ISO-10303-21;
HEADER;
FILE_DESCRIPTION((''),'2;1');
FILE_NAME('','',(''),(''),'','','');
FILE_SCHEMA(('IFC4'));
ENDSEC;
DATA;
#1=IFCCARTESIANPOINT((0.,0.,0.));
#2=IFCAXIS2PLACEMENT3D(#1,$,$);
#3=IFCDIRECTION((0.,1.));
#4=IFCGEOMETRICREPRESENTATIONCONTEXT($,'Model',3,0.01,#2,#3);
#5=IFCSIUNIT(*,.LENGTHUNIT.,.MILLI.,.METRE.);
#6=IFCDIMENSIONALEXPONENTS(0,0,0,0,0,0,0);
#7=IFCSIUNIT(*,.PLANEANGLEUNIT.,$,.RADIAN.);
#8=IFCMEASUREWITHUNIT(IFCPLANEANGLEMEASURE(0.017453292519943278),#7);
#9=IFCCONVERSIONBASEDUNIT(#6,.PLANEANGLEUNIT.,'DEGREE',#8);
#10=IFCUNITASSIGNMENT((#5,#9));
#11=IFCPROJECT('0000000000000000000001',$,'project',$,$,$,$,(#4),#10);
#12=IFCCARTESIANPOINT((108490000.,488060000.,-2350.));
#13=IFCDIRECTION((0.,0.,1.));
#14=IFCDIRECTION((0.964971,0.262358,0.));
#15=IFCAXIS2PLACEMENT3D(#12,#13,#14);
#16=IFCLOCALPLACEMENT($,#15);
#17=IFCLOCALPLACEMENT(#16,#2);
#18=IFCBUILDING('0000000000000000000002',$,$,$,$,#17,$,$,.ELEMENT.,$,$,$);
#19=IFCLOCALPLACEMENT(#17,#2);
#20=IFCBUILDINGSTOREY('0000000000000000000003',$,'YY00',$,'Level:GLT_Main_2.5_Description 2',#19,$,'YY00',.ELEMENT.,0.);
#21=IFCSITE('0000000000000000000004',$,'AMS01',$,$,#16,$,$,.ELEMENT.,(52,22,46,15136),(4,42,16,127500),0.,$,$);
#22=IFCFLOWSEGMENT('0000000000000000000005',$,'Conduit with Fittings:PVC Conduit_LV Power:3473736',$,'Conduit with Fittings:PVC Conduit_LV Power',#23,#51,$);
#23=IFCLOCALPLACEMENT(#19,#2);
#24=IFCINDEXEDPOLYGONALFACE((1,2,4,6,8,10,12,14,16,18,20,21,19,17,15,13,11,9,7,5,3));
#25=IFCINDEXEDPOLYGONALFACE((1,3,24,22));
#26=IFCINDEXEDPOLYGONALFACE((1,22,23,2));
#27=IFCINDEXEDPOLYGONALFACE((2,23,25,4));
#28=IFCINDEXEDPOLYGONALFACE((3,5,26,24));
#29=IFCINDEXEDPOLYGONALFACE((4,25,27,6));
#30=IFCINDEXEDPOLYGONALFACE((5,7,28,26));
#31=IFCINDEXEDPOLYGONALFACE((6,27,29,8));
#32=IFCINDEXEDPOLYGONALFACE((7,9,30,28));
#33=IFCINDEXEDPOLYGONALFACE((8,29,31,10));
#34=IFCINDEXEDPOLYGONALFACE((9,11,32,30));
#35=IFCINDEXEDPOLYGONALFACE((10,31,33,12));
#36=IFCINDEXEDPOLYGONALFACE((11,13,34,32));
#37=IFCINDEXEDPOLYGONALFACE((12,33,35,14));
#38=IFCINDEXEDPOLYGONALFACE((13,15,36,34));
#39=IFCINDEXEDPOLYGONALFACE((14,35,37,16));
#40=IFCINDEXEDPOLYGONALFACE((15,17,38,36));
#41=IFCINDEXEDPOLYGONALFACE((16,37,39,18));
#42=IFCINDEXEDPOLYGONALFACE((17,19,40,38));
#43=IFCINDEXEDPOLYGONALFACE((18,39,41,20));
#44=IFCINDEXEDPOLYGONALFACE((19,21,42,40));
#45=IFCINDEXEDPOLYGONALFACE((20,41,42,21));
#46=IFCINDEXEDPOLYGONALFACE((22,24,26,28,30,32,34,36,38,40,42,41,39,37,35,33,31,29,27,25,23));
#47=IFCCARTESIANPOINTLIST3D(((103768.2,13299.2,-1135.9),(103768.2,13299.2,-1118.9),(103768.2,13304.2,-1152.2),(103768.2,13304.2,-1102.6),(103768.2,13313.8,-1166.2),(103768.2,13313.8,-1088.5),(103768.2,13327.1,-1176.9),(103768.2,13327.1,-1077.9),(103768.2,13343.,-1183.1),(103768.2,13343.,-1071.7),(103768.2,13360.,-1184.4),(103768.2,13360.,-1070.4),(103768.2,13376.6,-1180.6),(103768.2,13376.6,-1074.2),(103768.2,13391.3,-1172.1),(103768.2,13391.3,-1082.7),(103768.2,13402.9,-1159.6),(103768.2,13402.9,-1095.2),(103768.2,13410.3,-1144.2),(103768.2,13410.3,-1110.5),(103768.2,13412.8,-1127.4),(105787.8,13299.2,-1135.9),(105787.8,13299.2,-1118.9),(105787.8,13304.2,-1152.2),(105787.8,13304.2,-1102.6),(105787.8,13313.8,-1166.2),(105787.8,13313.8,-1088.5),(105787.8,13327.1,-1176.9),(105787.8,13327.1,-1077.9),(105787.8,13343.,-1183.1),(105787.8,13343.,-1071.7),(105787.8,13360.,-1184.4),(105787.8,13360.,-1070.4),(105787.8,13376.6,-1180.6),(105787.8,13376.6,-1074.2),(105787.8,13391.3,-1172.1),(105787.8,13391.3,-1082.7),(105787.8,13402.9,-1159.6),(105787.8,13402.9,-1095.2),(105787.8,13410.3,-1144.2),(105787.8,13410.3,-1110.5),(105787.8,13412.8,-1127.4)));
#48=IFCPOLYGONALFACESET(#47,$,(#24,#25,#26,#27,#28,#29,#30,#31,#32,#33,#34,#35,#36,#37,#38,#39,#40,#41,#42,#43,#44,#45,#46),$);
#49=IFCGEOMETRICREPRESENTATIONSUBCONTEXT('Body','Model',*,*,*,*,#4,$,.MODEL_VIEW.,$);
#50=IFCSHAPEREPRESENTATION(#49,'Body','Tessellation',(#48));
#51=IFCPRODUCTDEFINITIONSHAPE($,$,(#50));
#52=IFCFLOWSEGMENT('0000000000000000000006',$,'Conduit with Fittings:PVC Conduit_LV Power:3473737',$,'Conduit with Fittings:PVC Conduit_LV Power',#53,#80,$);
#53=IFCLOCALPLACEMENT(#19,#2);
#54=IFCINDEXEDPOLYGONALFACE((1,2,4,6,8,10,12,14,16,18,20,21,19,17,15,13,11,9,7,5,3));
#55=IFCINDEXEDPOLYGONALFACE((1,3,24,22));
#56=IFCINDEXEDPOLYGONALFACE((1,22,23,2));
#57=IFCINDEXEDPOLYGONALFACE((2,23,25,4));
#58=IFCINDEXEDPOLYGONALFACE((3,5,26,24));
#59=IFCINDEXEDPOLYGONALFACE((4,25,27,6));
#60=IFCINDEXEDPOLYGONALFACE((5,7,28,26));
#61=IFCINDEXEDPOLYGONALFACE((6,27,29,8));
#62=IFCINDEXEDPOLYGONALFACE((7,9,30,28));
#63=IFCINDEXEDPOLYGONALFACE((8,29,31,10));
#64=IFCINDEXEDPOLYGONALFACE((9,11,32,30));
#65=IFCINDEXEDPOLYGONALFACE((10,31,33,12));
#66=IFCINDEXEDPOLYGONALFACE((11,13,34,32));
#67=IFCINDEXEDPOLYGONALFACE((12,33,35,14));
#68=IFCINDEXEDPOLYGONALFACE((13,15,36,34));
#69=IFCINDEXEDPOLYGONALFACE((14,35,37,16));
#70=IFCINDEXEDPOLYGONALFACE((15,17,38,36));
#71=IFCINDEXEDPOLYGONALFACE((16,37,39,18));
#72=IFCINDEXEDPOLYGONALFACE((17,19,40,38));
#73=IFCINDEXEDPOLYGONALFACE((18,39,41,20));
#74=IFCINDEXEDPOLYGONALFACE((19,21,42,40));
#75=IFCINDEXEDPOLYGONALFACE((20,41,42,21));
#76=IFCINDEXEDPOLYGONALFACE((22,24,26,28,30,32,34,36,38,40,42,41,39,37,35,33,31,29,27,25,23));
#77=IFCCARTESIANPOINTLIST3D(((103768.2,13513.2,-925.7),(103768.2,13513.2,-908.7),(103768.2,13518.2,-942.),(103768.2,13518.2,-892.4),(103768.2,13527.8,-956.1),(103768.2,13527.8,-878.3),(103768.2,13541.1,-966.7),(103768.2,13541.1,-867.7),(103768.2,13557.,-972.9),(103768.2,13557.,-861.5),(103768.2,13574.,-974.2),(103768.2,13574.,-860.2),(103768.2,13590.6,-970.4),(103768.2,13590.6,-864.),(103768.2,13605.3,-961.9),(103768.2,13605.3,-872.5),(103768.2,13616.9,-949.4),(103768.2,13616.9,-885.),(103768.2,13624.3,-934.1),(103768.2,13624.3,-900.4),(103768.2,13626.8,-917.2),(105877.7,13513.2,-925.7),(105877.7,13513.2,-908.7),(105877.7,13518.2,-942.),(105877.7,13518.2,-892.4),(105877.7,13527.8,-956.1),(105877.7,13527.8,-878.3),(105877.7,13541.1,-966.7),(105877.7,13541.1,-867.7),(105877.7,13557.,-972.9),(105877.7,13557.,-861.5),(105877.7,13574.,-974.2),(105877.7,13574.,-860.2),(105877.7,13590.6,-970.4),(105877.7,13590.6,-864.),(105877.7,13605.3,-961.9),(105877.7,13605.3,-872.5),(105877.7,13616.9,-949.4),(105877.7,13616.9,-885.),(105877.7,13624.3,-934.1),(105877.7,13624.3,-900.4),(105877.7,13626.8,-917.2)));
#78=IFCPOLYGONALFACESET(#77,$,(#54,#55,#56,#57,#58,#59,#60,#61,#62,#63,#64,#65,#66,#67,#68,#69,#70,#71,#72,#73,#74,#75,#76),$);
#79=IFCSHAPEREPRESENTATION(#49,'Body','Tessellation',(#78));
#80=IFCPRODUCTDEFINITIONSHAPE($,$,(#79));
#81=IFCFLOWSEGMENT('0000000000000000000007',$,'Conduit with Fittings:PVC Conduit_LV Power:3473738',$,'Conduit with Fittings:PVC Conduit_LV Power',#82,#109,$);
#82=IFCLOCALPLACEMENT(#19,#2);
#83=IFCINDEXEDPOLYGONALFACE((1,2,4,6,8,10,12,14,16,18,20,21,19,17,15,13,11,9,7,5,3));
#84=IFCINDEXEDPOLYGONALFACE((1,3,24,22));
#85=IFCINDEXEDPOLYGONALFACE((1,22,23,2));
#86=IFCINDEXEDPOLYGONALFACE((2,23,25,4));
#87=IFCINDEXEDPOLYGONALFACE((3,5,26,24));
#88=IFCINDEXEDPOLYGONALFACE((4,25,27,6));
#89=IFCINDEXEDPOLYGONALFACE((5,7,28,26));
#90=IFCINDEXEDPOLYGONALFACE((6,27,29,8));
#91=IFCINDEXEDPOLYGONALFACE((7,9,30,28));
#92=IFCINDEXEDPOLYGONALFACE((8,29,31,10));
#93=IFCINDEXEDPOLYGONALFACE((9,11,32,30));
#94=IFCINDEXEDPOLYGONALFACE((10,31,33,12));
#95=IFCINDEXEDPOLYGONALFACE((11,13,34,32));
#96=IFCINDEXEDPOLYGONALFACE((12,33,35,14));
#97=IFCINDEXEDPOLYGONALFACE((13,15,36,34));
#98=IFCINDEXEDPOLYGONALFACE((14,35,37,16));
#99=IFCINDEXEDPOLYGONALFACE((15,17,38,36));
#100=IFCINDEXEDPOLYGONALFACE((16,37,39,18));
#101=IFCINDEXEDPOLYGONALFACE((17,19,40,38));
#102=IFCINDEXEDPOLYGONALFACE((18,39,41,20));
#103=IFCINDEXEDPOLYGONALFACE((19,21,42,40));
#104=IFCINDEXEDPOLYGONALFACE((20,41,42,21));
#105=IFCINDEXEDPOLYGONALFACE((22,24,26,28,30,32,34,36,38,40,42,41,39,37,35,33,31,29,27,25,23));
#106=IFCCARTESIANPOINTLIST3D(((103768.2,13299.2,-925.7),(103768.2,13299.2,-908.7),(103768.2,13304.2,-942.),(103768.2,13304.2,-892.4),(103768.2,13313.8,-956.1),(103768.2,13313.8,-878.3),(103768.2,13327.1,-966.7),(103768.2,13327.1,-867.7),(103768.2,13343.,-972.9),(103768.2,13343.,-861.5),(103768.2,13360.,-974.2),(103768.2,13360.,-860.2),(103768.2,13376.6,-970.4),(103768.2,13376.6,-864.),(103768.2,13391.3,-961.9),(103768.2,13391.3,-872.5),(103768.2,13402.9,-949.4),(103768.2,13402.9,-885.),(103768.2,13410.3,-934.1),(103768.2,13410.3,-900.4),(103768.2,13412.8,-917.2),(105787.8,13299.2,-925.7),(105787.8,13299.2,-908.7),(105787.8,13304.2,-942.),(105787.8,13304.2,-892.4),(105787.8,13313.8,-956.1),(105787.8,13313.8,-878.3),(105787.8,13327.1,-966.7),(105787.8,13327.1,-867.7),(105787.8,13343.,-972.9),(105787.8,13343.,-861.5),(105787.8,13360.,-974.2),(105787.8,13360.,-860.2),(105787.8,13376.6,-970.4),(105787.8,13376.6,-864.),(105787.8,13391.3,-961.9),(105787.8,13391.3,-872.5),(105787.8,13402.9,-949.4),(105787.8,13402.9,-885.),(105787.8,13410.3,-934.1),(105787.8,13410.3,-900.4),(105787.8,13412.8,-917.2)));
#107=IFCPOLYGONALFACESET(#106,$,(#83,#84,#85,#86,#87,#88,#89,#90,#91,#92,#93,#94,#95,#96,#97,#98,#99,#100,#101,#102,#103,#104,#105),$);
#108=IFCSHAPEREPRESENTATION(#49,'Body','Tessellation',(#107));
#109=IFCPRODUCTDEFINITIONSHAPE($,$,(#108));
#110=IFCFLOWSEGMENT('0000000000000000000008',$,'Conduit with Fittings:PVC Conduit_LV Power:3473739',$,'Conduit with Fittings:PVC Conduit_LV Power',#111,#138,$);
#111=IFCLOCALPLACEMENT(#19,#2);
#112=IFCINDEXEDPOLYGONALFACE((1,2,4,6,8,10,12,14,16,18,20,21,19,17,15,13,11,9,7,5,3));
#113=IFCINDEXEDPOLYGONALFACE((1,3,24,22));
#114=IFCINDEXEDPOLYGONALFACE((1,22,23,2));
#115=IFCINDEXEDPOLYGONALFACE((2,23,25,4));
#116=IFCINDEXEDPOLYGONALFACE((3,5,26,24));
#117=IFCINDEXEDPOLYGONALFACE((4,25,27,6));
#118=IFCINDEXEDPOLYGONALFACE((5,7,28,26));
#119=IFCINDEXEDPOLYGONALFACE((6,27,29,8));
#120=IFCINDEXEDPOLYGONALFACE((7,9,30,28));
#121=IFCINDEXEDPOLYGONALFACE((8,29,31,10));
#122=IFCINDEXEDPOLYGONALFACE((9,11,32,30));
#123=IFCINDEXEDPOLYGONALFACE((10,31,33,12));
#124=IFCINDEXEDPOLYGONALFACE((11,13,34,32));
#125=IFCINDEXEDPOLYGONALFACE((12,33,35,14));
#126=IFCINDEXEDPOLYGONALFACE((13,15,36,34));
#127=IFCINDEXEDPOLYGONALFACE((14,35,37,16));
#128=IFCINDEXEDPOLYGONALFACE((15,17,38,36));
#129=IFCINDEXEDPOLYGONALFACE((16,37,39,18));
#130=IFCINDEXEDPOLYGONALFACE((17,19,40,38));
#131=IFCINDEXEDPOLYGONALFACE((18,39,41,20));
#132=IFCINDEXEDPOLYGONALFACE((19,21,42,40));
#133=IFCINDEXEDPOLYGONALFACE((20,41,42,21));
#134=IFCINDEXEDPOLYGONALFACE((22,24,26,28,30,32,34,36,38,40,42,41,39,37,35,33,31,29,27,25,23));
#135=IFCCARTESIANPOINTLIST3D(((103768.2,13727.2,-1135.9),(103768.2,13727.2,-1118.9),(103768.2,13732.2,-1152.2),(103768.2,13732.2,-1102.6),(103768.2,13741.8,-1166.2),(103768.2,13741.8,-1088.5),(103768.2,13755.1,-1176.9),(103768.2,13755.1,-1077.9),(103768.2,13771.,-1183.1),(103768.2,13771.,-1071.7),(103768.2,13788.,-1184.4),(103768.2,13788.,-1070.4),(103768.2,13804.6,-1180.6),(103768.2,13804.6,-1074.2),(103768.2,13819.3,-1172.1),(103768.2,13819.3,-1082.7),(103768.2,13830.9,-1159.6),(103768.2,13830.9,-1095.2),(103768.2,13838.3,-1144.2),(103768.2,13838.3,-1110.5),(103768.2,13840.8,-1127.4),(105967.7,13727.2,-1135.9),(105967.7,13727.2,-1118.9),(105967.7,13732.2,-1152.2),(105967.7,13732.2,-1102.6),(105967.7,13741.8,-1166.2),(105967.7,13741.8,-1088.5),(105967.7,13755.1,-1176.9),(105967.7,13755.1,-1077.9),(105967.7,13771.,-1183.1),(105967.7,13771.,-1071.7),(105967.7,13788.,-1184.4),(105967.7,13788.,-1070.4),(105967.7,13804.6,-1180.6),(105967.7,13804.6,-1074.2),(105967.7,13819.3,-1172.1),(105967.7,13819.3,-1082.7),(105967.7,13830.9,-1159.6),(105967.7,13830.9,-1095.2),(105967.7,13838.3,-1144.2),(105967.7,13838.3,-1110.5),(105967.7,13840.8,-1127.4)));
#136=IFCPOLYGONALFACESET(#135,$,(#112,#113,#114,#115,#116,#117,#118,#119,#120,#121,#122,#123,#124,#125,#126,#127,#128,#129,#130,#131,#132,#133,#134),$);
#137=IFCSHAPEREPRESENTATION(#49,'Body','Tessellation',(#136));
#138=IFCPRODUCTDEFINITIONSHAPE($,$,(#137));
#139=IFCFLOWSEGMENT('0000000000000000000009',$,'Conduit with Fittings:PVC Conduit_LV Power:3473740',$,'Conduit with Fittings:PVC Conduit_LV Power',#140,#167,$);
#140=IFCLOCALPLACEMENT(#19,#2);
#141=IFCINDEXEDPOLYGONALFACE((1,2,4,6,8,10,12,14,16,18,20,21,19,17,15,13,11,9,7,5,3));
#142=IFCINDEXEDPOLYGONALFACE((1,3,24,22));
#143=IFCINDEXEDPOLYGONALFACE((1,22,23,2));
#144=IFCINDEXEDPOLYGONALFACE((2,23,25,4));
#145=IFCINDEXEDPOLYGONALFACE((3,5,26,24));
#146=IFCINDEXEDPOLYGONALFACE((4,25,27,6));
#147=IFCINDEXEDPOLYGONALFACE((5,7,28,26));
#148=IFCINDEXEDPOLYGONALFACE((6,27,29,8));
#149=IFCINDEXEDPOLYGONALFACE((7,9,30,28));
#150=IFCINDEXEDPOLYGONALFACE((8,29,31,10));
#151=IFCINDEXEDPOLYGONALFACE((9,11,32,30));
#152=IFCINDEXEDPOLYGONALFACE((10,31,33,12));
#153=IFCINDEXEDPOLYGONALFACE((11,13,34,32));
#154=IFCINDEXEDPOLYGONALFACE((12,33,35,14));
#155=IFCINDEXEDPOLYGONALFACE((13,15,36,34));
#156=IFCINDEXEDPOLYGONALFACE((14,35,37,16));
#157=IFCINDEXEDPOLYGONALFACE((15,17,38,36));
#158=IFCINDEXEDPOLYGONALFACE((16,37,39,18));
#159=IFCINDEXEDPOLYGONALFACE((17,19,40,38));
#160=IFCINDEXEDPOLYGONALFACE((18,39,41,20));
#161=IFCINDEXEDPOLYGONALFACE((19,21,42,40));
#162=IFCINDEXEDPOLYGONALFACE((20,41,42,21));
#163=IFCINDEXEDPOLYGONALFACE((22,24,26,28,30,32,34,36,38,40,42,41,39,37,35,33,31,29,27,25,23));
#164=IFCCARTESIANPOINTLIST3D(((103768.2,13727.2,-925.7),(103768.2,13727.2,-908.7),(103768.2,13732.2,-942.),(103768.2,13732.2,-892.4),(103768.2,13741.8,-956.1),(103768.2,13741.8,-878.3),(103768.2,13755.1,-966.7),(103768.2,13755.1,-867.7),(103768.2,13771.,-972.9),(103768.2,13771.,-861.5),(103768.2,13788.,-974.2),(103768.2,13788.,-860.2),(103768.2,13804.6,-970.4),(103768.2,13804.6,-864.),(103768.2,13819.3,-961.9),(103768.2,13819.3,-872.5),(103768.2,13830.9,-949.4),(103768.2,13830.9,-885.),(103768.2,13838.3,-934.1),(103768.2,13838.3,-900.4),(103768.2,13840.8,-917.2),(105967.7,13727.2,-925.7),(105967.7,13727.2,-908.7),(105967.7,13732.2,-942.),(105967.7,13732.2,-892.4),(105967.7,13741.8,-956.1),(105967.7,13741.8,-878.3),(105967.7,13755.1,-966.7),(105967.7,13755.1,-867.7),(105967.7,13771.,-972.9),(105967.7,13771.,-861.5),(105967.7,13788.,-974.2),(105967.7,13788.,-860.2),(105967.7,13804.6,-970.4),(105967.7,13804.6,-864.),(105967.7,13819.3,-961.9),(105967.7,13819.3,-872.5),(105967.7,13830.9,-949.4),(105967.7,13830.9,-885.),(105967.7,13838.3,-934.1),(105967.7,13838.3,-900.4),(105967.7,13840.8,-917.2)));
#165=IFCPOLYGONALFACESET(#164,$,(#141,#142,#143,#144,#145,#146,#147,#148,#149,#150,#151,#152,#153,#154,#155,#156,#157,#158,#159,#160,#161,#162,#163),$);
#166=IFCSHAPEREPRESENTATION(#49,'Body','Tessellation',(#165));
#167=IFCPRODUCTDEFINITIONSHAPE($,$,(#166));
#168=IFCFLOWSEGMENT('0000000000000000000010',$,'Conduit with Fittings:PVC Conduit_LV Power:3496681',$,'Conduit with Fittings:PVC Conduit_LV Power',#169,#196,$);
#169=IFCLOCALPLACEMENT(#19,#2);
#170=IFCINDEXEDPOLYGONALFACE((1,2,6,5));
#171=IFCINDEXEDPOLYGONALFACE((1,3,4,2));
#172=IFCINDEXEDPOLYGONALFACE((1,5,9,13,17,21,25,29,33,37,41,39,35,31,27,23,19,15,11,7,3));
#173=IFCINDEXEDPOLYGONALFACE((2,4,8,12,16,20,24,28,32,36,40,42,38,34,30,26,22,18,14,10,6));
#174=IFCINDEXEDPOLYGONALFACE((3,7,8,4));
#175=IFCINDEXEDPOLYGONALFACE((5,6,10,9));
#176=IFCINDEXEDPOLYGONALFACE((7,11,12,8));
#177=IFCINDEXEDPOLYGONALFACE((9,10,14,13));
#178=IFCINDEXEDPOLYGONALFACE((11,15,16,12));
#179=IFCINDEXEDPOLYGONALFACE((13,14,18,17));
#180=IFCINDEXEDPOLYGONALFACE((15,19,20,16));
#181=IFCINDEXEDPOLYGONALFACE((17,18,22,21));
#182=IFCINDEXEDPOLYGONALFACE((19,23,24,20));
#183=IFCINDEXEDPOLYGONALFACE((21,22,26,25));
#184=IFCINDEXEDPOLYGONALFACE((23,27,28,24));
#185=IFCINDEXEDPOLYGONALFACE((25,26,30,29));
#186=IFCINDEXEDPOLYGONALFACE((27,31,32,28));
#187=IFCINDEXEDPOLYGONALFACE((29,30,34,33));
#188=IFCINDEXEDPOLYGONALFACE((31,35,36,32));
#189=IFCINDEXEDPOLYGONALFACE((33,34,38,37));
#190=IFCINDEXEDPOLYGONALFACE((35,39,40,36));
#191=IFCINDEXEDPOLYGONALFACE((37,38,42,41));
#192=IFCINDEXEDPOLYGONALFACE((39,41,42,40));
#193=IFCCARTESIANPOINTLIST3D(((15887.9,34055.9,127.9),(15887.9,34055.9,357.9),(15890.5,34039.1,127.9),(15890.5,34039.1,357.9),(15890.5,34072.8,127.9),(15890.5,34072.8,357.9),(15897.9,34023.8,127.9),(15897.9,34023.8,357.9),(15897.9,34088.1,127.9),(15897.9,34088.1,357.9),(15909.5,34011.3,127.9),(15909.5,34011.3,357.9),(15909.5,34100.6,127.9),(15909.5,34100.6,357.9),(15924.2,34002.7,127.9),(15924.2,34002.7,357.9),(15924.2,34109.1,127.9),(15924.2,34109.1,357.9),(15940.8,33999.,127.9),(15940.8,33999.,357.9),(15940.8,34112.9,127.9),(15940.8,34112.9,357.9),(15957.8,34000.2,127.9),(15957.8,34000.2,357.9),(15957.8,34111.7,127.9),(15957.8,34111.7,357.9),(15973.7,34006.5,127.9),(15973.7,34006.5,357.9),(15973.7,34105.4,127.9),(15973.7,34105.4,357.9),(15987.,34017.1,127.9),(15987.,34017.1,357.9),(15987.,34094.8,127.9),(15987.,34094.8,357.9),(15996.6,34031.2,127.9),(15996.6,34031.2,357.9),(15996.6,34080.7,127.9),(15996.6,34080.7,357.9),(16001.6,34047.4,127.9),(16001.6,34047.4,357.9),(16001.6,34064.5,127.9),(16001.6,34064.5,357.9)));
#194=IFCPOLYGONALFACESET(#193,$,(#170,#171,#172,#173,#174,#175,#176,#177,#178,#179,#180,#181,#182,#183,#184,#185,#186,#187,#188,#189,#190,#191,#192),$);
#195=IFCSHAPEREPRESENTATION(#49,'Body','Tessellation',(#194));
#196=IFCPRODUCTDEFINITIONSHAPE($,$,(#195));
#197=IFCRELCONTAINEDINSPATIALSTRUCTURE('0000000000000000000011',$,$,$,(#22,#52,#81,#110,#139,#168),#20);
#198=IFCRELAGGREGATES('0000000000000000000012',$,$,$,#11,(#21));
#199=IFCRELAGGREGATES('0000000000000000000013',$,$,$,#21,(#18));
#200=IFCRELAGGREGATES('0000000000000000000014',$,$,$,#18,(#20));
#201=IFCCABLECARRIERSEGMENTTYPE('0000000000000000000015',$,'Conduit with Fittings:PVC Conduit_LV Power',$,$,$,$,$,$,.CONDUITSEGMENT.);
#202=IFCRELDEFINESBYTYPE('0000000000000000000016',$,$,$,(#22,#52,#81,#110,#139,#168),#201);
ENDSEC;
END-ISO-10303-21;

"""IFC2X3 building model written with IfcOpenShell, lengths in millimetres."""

from ifc_helpers import new_model, entity, si_unit, converted_unit, direction, frame, frame_2d, origin, origin_2d_with_axis, place, context, subcontext, project, spatial, circle, extrude, type_object, element, save


model = new_model("IFC2X3")

# Units and contexts
model_context = context("Model", 3, precision=0.01, world=origin(), true_north=direction((0.0, 1.0)))
body_context = subcontext(model_context, "Body", "Model", "MODEL_VIEW")
ifc_project = project(units=[si_unit("LENGTHUNIT", "METRE", prefix="MILLI"), converted_unit("PLANEANGLEUNIT", "DEGREE", entity("IfcPlaneAngleMeasure", 0.017453292519943278), si_unit("PLANEANGLEUNIT", "RADIAN"), dimensions=[0, 0, 0, 0, 0, 0, 0])], contexts=[model_context])

# Site, building, storey
site_placement = place(None, frame((108490000.0, 488060000.0, -2350.0), z_axis=(0.0, 0.0, 1.0), x_axis=(0.964971, 0.262358, 0.0)))
site = spatial("IfcSite", under=ifc_project, at=site_placement, Name="AMS01", CompositionType="ELEMENT", RefLatitude=(52, 22, 46, 15136), RefLongitude=(4, 42, 16, 127500), RefElevation=0.0)
building_placement = place(site_placement, origin())
building = spatial("IfcBuilding", under=site, at=building_placement, CompositionType="ELEMENT")
storey_placement = place(building_placement, origin())
storey = spatial("IfcBuildingStorey", under=building, at=storey_placement, Name="YY00", ObjectType="Level:GLT_Main_2.5_Description 2", LongName="YY00", CompositionType="ELEMENT", Elevation=0.0)

# Flow segments
cable_carrier_segment_type = type_object("IfcCableCarrierSegmentType", Name="Conduit with Fittings:PVC Conduit_LV Power", PredefinedType="CONDUITSEGMENT")
flow_segment_1_placement = place(storey_placement, origin())
element("IfcFlowSegment", 1, at=flow_segment_1_placement, inside=storey, type_object=cable_carrier_segment_type, Name="Conduit with Fittings:PVC Conduit_LV Power:3473736", ObjectType="Conduit with Fittings:PVC Conduit_LV Power", context=body_context, shape_type="SweptSolid", body=[
    extrude(circle(Radius=57.2, at=frame_2d((0.0, 0.0), x_axis=(1.0, 0.0))), frame((103768.2, 13355.7, -1127.4), z_axis=(1.0, 0.0, 0.0), x_axis=(0.0, 1.0, 0.0)), (0.0, 0.0, 1.0), 2019.5),
])
flow_segment_2_placement = place(storey_placement, origin())
element("IfcFlowSegment", 2, at=flow_segment_2_placement, inside=storey, type_object=cable_carrier_segment_type, Name="Conduit with Fittings:PVC Conduit_LV Power:3473737", ObjectType="Conduit with Fittings:PVC Conduit_LV Power", context=body_context, shape_type="SweptSolid", body=[
    extrude(circle(Radius=57.2, at=frame_2d((0.0, 0.0), x_axis=(1.0, 0.0))), frame((103768.2, 13569.7, -917.2), z_axis=(1.0, 0.0, 0.0), x_axis=(0.0, 1.0, 0.0)), (0.0, 0.0, 1.0), 2109.5),
])
flow_segment_3_placement = place(storey_placement, origin())
element("IfcFlowSegment", 3, at=flow_segment_3_placement, inside=storey, type_object=cable_carrier_segment_type, Name="Conduit with Fittings:PVC Conduit_LV Power:3473738", ObjectType="Conduit with Fittings:PVC Conduit_LV Power", context=body_context, shape_type="SweptSolid", body=[
    extrude(circle(Radius=57.2, at=frame_2d((0.0, 0.0), x_axis=(1.0, 0.0))), frame((103768.2, 13355.7, -917.2), z_axis=(1.0, 0.0, 0.0), x_axis=(0.0, 1.0, 0.0)), (0.0, 0.0, 1.0), 2019.5),
])
flow_segment_4_placement = place(storey_placement, origin())
element("IfcFlowSegment", 4, at=flow_segment_4_placement, inside=storey, type_object=cable_carrier_segment_type, Name="Conduit with Fittings:PVC Conduit_LV Power:3473739", ObjectType="Conduit with Fittings:PVC Conduit_LV Power", context=body_context, shape_type="SweptSolid", body=[
    extrude(circle(Radius=57.2, at=frame_2d((0.0, 0.0), x_axis=(1.0, 0.0))), frame((103768.2, 13783.7, -1127.4), z_axis=(1.0, 0.0, 0.0), x_axis=(0.0, 1.0, 0.0)), (0.0, 0.0, 1.0), 2199.5),
])
flow_segment_5_placement = place(storey_placement, origin())
element("IfcFlowSegment", 5, at=flow_segment_5_placement, inside=storey, type_object=cable_carrier_segment_type, Name="Conduit with Fittings:PVC Conduit_LV Power:3473740", ObjectType="Conduit with Fittings:PVC Conduit_LV Power", context=body_context, shape_type="SweptSolid", body=[
    extrude(circle(Radius=57.2, at=frame_2d((0.0, 0.0), x_axis=(1.0, 0.0))), frame((103768.2, 13783.7, -917.2), z_axis=(1.0, 0.0, 0.0), x_axis=(0.0, 1.0, 0.0)), (0.0, 0.0, 1.0), 2199.5),
])
flow_segment_6_placement = place(storey_placement, origin())
element("IfcFlowSegment", 6, at=flow_segment_6_placement, inside=storey, type_object=cable_carrier_segment_type, Name="Conduit with Fittings:PVC Conduit_LV Power:3496681", ObjectType="Conduit with Fittings:PVC Conduit_LV Power", context=body_context, shape_type="SweptSolid", body=[
    extrude(circle(Radius=57.2, at=origin_2d_with_axis()), frame((15945.1, 34055.9, 127.9), z_axis=(0.0, 0.0, 1.0), x_axis=(-1.0, 0.0, 0.0)), (0.0, 0.0, 1.0), 230.0),
])

save(model, "model.ifc")
